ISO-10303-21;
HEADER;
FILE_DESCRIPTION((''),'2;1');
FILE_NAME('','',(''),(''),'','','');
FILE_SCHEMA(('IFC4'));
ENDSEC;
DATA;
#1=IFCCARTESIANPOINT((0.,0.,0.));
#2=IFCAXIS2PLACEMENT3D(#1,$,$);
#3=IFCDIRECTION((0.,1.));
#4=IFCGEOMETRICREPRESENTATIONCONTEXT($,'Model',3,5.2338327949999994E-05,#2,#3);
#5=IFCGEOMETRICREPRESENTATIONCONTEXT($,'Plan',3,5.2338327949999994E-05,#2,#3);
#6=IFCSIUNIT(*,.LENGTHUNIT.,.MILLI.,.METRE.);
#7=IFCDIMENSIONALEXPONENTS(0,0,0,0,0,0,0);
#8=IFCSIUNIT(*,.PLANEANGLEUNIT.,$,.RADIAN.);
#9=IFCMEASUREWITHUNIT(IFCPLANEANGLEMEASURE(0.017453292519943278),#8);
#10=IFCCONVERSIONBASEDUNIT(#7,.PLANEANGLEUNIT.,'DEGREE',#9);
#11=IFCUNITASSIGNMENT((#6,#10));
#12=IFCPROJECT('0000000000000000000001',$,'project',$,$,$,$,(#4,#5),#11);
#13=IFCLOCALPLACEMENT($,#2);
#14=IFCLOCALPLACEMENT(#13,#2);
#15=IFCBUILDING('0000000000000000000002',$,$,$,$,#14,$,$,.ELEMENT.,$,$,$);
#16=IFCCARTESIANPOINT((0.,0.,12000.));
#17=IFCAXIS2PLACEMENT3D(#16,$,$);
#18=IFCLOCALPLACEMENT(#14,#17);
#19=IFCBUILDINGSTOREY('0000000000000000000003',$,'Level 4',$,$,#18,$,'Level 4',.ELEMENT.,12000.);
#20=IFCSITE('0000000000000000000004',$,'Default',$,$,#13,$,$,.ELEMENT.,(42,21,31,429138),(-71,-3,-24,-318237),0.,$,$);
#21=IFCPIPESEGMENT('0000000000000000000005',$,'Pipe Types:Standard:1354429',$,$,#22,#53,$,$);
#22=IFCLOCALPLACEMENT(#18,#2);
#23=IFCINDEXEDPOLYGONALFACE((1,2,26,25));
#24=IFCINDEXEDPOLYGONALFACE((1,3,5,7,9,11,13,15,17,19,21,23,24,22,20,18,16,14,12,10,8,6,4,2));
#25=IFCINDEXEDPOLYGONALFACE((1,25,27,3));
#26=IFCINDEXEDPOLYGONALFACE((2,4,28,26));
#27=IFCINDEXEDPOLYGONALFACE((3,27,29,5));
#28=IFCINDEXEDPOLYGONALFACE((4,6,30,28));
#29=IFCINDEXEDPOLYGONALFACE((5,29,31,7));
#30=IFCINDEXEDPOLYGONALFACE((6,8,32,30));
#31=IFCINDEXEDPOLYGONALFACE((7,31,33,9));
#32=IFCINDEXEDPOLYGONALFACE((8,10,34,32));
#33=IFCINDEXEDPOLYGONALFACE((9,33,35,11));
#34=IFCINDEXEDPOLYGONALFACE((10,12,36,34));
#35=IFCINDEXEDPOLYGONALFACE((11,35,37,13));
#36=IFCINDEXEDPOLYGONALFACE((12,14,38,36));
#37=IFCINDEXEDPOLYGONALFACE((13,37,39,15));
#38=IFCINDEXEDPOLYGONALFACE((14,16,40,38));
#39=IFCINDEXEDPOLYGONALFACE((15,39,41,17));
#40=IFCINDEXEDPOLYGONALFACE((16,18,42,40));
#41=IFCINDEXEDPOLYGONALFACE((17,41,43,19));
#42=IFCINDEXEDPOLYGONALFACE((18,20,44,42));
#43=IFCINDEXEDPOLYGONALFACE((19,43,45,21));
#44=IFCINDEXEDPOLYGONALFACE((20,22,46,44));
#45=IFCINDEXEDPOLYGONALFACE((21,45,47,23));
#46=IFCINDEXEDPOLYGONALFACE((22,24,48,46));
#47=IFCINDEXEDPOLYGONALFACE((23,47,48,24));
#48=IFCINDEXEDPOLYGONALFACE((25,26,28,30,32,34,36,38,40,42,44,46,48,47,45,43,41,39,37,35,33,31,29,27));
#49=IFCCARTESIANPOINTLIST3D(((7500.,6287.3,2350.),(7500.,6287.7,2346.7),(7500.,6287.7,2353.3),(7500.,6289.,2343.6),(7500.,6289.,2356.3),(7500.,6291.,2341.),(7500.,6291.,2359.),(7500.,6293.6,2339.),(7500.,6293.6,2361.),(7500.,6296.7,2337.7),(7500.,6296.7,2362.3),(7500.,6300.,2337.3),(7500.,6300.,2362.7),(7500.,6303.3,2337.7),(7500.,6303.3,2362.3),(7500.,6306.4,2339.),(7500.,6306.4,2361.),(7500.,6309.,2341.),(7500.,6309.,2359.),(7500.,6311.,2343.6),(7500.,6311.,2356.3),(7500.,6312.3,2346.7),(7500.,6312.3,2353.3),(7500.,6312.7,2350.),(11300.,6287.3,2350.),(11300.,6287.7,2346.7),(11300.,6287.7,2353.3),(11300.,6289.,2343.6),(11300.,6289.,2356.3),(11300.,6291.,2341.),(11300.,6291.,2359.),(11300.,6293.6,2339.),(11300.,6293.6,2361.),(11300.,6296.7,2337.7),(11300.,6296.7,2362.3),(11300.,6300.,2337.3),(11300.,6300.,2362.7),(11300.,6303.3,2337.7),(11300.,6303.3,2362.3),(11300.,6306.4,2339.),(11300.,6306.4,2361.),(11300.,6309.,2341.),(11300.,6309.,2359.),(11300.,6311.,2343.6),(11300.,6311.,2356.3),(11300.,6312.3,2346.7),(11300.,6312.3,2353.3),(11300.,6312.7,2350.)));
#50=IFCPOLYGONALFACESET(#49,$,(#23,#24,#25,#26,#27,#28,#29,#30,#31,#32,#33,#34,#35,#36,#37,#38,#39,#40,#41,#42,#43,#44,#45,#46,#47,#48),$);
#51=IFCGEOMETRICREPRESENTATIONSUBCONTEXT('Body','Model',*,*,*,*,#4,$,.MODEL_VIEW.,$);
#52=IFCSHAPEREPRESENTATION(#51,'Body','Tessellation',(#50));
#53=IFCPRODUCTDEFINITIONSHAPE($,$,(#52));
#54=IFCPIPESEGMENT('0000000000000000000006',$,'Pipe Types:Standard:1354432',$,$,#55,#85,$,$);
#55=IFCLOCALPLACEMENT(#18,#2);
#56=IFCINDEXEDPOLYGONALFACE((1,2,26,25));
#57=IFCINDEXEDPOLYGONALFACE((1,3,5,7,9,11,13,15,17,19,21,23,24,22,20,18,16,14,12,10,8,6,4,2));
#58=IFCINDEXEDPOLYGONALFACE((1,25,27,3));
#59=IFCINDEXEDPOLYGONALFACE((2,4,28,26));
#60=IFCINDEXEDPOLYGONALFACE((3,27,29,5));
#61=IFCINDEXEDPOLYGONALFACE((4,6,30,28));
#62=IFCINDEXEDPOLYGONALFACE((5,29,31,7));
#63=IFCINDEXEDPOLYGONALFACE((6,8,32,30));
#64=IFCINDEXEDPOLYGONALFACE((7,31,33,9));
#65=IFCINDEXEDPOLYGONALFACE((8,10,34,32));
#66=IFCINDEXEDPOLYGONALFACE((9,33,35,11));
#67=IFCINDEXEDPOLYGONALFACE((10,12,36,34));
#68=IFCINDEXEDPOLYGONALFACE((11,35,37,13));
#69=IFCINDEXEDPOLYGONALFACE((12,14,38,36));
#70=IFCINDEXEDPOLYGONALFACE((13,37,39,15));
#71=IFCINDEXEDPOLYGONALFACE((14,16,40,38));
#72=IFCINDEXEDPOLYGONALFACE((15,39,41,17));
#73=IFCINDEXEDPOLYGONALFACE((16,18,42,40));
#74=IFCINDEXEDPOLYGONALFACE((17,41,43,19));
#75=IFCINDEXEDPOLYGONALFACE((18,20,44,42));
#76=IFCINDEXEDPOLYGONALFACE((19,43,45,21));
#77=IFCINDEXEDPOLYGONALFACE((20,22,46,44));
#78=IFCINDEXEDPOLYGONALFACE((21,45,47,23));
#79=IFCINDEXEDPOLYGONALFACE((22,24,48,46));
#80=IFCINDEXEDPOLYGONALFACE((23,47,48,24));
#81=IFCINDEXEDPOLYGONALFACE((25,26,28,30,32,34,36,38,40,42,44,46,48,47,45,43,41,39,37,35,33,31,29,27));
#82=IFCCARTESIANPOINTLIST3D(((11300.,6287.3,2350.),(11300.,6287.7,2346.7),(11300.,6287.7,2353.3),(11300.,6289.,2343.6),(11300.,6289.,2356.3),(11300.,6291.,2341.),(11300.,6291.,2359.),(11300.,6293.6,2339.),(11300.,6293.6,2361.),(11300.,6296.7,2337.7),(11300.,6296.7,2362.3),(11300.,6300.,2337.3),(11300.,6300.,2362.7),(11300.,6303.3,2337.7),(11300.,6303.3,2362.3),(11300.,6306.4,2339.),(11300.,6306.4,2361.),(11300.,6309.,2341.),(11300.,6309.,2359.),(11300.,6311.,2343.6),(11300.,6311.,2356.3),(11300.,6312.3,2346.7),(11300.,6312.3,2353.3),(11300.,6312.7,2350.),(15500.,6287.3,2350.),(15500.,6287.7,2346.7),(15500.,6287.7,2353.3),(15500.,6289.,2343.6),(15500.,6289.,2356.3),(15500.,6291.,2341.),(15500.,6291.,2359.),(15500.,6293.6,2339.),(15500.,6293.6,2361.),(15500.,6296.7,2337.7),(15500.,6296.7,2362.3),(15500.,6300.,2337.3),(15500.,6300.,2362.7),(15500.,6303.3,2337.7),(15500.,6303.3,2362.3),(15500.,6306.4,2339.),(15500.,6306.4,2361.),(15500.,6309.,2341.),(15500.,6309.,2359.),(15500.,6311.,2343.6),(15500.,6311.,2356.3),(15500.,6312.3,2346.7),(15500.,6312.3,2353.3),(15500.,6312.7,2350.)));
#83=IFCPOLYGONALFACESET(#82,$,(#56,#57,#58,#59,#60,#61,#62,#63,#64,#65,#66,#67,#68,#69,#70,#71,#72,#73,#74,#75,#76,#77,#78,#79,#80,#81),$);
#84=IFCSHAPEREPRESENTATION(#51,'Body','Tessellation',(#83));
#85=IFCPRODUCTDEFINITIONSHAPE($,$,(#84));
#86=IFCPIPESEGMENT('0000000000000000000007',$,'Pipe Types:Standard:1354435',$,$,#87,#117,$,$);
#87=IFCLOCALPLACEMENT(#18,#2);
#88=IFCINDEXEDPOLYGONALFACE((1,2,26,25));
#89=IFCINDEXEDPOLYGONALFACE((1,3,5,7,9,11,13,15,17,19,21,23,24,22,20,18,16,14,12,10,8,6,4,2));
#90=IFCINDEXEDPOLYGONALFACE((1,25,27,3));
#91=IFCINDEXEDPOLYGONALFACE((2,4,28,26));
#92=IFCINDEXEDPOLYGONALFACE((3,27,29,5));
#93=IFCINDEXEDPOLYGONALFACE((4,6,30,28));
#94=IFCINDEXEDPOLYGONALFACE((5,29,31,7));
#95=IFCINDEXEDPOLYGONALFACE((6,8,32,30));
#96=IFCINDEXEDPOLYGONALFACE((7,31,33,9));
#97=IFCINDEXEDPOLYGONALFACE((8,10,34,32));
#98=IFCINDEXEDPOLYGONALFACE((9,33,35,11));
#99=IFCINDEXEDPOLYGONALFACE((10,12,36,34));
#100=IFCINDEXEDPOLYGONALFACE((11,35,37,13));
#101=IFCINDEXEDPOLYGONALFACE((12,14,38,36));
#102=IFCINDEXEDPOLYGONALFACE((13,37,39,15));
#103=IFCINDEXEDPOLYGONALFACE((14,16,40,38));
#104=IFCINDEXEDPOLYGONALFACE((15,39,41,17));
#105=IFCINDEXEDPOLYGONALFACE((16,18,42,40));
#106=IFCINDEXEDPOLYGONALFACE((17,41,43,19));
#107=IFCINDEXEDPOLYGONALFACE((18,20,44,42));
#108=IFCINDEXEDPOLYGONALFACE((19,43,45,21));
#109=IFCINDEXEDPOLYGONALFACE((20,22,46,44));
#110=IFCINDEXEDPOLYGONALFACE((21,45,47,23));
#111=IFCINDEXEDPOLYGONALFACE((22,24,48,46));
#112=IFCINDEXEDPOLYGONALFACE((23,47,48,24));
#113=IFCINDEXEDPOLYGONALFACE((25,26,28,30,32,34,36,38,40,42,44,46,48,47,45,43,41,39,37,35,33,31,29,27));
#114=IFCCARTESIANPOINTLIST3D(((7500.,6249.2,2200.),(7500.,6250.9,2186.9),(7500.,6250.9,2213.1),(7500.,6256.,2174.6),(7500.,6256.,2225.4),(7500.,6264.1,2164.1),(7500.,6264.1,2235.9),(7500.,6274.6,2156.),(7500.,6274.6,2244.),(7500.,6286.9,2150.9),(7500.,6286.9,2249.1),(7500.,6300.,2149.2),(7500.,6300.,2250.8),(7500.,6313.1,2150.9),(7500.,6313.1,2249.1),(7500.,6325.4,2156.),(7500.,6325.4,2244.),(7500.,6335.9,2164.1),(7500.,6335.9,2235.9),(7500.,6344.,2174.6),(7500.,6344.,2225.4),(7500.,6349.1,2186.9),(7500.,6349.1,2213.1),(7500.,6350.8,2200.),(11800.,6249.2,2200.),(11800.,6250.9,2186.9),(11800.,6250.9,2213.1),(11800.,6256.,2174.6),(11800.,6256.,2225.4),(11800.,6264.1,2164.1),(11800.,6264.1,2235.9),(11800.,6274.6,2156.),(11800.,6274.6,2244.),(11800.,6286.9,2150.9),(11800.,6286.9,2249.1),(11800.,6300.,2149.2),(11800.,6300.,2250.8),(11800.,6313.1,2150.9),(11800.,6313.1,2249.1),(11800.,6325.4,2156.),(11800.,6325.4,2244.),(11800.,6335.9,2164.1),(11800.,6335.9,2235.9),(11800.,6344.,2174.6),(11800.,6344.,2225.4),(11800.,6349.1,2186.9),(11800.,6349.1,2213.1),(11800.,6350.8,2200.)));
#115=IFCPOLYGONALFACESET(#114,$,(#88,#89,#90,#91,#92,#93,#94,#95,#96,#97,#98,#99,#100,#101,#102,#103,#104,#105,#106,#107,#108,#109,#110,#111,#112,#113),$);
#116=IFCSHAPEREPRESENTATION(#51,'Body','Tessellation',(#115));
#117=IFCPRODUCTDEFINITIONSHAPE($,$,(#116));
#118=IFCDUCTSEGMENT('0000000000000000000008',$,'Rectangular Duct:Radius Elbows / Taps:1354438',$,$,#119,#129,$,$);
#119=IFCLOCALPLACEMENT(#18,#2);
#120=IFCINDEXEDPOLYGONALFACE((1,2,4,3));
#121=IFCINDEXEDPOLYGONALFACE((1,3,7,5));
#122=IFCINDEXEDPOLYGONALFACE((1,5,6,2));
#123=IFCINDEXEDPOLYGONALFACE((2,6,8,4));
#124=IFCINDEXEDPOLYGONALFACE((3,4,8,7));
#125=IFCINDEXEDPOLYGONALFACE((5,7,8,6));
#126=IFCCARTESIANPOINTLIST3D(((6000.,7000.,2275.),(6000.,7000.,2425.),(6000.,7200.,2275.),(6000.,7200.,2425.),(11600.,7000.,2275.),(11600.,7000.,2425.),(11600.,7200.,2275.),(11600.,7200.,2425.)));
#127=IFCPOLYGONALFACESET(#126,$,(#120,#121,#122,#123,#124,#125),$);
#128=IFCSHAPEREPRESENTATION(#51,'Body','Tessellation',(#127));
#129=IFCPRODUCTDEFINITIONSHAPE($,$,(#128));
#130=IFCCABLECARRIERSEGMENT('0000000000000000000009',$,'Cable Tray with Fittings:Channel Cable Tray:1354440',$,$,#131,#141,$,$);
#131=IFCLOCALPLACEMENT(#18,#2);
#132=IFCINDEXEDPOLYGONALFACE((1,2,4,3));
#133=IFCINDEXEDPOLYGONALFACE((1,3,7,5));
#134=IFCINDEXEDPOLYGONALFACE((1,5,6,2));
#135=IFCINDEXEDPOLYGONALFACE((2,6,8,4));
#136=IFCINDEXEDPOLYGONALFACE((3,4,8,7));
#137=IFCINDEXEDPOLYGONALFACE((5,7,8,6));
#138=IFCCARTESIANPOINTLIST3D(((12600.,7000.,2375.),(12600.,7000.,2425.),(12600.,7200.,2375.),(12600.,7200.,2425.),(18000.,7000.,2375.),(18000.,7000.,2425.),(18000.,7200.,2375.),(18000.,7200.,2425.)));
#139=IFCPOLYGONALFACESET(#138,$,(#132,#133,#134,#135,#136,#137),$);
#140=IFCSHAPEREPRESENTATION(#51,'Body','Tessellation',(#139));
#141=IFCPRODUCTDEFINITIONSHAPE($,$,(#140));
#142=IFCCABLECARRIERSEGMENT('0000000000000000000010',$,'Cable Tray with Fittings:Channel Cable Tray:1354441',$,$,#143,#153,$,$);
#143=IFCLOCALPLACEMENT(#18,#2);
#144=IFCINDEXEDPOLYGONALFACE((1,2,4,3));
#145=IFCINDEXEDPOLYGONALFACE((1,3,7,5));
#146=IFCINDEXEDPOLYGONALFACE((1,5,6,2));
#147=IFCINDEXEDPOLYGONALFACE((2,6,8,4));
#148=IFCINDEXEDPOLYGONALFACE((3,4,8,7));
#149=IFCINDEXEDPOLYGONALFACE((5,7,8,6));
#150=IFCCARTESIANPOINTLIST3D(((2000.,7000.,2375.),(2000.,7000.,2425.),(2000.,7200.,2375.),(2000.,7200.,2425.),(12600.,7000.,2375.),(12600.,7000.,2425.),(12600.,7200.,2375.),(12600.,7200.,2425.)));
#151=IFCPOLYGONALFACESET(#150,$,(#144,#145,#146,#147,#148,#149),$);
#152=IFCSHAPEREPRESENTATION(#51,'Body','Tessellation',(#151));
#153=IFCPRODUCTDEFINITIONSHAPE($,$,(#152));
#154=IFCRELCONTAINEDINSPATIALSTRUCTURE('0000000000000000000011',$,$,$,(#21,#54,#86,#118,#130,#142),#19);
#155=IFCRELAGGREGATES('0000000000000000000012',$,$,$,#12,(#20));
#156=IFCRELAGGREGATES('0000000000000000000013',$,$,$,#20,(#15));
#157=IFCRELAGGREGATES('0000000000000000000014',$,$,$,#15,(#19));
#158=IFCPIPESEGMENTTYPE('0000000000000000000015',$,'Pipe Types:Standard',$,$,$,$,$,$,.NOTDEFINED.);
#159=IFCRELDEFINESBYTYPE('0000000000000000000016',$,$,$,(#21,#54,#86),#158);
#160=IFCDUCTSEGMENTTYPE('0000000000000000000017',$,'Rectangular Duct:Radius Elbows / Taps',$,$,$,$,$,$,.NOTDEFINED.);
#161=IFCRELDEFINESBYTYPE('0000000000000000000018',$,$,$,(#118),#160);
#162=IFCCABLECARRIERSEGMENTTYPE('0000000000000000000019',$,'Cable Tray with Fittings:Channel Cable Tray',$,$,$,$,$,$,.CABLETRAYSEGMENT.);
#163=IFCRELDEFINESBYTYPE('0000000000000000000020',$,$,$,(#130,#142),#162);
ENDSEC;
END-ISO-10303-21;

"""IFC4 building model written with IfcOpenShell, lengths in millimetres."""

from ifc_helpers import new_model, entity, si_unit, converted_unit, direction, frame, origin, place, context, subcontext, project, spatial, arc, indexed_curve, outline, extrude, type_object, element, save


model = new_model("IFC4")

# Units and contexts
model_context = context("Model", 3, precision=5.2338327949999994e-05, world=origin(), true_north=direction((0.0, 1.0)))
plan_context = context("Plan", 3, precision=5.2338327949999994e-05, world=origin(), true_north=direction((0.0, 1.0)))
body_context = subcontext(model_context, "Body", "Model", "MODEL_VIEW")
ifc_project = project(units=[si_unit("LENGTHUNIT", "METRE", prefix="MILLI"), converted_unit("PLANEANGLEUNIT", "DEGREE", entity("IfcPlaneAngleMeasure", 0.017453292519943278), si_unit("PLANEANGLEUNIT", "RADIAN"), dimensions=[0, 0, 0, 0, 0, 0, 0])], contexts=[model_context, plan_context])

# Site, building, storey
site_placement = place(None, origin())
site = spatial("IfcSite", under=ifc_project, at=site_placement, Name="Default", CompositionType="ELEMENT", RefLatitude=(42, 21, 31, 429138), RefLongitude=(-71, -3, -24, -318237), RefElevation=0.0)
building_placement = place(site_placement, origin())
building = spatial("IfcBuilding", under=site, at=building_placement, CompositionType="ELEMENT")
storey_placement = place(building_placement, frame((0.0, 0.0, 12000.0)))
storey = spatial("IfcBuildingStorey", under=building, at=storey_placement, Name="Level 4", LongName="Level 4", CompositionType="ELEMENT", Elevation=12000.0)

# Pipe segments
pipe_segment_type = type_object("IfcPipeSegmentType", Name="Pipe Types:Standard", PredefinedType="NOTDEFINED")
pipe_segment_1_placement = place(storey_placement, origin())
element("IfcPipeSegment", 1, at=pipe_segment_1_placement, inside=storey, type_object=pipe_segment_type, Name="Pipe Types:Standard:1354429", context=body_context, shape_type="SweptSolid", body=[
    extrude(outline(indexed_curve([(12.7, 0.0), (9.0, 9.0), (0.0, 12.7), (-9.0, 9.0), (-12.7, 0.0), (-9.0, -9.0), (0.0, -12.7), (9.0, -9.0)], segments=[arc(1, 2, 3), arc(3, 4, 5), arc(5, 6, 7), arc(7, 8, 1)], self_intersect=False)), frame((7500.0, 6300.0, 2350.0), z_axis=(1.0, 0.0, 0.0), x_axis=(0.0, 1.0, 0.0)), (0.0, 0.0, 1.0), 3800.0),
])
pipe_segment_2_placement = place(storey_placement, origin())
element("IfcPipeSegment", 2, at=pipe_segment_2_placement, inside=storey, type_object=pipe_segment_type, Name="Pipe Types:Standard:1354432", context=body_context, shape_type="SweptSolid", body=[
    extrude(outline(indexed_curve([(12.7, 0.0), (9.0, 9.0), (0.0, 12.7), (-9.0, 9.0), (-12.7, 0.0), (-9.0, -9.0), (0.0, -12.7), (9.0, -9.0)], segments=[arc(1, 2, 3), arc(3, 4, 5), arc(5, 6, 7), arc(7, 8, 1)], self_intersect=False)), frame((11300.0, 6300.0, 2350.0), z_axis=(1.0, 0.0, 0.0), x_axis=(0.0, -1.0, 0.0)), (0.0, 0.0, 1.0), 4200.0),
])
pipe_segment_3_placement = place(storey_placement, origin())
element("IfcPipeSegment", 3, at=pipe_segment_3_placement, inside=storey, type_object=pipe_segment_type, Name="Pipe Types:Standard:1354435", context=body_context, shape_type="SweptSolid", body=[
    extrude(outline(indexed_curve([(50.8, 0.0), (35.9, 35.9), (0.0, 50.8), (-35.9, 35.9), (-50.8, 0.0), (-35.9, -35.9), (0.0, -50.8), (35.9, -35.9)], segments=[arc(1, 2, 3), arc(3, 4, 5), arc(5, 6, 7), arc(7, 8, 1)], self_intersect=False)), frame((7500.0, 6300.0, 2200.0), z_axis=(1.0, 0.0, 0.0), x_axis=(0.0, 1.0, 0.0)), (0.0, 0.0, 1.0), 4300.0),
])

# Duct segment
duct_segment_type = type_object("IfcDuctSegmentType", Name="Rectangular Duct:Radius Elbows / Taps", PredefinedType="NOTDEFINED")
duct_segment_placement = place(storey_placement, origin())
element("IfcDuctSegment", 4, at=duct_segment_placement, inside=storey, type_object=duct_segment_type, Name="Rectangular Duct:Radius Elbows / Taps:1354438", context=body_context, shape_type="SweptSolid", body=[
    extrude(outline(indexed_curve([(-2800.0, -100.0), (2800.0, -100.0), (2800.0, 100.0), (-2800.0, 100.0), (-2800.0, -100.0)], self_intersect=False)), frame((8800.0, 7100.0, 2275.0), z_axis=(0.0, 0.0, 1.0), x_axis=(-1.0, 0.0, 0.0)), (0.0, 0.0, 1.0), 150.0),
])

# Cable carrier segments
cable_carrier_segment_type = type_object("IfcCableCarrierSegmentType", Name="Cable Tray with Fittings:Channel Cable Tray", PredefinedType="CABLETRAYSEGMENT")
cable_carrier_segment_1_placement = place(storey_placement, origin())
element("IfcCableCarrierSegment", 5, at=cable_carrier_segment_1_placement, inside=storey, type_object=cable_carrier_segment_type, Name="Cable Tray with Fittings:Channel Cable Tray:1354440", context=body_context, shape_type="SweptSolid", body=[
    extrude(outline(indexed_curve([(-2700.0, -100.0), (2700.0, -100.0), (2700.0, 100.0), (-2700.0, 100.0), (-2700.0, -100.0)], self_intersect=False)), frame((15300.0, 7100.0, 2375.0)), (0.0, 0.0, 1.0), 50.0),
])
cable_carrier_segment_2_placement = place(storey_placement, origin())
element("IfcCableCarrierSegment", 6, at=cable_carrier_segment_2_placement, inside=storey, type_object=cable_carrier_segment_type, Name="Cable Tray with Fittings:Channel Cable Tray:1354441", context=body_context, shape_type="SweptSolid", body=[
    extrude(outline(indexed_curve([(-5300.0, -100.0), (5300.0, -100.0), (5300.0, 100.0), (-5300.0, 100.0), (-5300.0, -100.0)], self_intersect=False)), frame((7300.0, 7100.0, 2375.0), z_axis=(0.0, 0.0, 1.0), x_axis=(-1.0, 0.0, 0.0)), (0.0, 0.0, 1.0), 50.0),
])

save(model, "model.ifc")
